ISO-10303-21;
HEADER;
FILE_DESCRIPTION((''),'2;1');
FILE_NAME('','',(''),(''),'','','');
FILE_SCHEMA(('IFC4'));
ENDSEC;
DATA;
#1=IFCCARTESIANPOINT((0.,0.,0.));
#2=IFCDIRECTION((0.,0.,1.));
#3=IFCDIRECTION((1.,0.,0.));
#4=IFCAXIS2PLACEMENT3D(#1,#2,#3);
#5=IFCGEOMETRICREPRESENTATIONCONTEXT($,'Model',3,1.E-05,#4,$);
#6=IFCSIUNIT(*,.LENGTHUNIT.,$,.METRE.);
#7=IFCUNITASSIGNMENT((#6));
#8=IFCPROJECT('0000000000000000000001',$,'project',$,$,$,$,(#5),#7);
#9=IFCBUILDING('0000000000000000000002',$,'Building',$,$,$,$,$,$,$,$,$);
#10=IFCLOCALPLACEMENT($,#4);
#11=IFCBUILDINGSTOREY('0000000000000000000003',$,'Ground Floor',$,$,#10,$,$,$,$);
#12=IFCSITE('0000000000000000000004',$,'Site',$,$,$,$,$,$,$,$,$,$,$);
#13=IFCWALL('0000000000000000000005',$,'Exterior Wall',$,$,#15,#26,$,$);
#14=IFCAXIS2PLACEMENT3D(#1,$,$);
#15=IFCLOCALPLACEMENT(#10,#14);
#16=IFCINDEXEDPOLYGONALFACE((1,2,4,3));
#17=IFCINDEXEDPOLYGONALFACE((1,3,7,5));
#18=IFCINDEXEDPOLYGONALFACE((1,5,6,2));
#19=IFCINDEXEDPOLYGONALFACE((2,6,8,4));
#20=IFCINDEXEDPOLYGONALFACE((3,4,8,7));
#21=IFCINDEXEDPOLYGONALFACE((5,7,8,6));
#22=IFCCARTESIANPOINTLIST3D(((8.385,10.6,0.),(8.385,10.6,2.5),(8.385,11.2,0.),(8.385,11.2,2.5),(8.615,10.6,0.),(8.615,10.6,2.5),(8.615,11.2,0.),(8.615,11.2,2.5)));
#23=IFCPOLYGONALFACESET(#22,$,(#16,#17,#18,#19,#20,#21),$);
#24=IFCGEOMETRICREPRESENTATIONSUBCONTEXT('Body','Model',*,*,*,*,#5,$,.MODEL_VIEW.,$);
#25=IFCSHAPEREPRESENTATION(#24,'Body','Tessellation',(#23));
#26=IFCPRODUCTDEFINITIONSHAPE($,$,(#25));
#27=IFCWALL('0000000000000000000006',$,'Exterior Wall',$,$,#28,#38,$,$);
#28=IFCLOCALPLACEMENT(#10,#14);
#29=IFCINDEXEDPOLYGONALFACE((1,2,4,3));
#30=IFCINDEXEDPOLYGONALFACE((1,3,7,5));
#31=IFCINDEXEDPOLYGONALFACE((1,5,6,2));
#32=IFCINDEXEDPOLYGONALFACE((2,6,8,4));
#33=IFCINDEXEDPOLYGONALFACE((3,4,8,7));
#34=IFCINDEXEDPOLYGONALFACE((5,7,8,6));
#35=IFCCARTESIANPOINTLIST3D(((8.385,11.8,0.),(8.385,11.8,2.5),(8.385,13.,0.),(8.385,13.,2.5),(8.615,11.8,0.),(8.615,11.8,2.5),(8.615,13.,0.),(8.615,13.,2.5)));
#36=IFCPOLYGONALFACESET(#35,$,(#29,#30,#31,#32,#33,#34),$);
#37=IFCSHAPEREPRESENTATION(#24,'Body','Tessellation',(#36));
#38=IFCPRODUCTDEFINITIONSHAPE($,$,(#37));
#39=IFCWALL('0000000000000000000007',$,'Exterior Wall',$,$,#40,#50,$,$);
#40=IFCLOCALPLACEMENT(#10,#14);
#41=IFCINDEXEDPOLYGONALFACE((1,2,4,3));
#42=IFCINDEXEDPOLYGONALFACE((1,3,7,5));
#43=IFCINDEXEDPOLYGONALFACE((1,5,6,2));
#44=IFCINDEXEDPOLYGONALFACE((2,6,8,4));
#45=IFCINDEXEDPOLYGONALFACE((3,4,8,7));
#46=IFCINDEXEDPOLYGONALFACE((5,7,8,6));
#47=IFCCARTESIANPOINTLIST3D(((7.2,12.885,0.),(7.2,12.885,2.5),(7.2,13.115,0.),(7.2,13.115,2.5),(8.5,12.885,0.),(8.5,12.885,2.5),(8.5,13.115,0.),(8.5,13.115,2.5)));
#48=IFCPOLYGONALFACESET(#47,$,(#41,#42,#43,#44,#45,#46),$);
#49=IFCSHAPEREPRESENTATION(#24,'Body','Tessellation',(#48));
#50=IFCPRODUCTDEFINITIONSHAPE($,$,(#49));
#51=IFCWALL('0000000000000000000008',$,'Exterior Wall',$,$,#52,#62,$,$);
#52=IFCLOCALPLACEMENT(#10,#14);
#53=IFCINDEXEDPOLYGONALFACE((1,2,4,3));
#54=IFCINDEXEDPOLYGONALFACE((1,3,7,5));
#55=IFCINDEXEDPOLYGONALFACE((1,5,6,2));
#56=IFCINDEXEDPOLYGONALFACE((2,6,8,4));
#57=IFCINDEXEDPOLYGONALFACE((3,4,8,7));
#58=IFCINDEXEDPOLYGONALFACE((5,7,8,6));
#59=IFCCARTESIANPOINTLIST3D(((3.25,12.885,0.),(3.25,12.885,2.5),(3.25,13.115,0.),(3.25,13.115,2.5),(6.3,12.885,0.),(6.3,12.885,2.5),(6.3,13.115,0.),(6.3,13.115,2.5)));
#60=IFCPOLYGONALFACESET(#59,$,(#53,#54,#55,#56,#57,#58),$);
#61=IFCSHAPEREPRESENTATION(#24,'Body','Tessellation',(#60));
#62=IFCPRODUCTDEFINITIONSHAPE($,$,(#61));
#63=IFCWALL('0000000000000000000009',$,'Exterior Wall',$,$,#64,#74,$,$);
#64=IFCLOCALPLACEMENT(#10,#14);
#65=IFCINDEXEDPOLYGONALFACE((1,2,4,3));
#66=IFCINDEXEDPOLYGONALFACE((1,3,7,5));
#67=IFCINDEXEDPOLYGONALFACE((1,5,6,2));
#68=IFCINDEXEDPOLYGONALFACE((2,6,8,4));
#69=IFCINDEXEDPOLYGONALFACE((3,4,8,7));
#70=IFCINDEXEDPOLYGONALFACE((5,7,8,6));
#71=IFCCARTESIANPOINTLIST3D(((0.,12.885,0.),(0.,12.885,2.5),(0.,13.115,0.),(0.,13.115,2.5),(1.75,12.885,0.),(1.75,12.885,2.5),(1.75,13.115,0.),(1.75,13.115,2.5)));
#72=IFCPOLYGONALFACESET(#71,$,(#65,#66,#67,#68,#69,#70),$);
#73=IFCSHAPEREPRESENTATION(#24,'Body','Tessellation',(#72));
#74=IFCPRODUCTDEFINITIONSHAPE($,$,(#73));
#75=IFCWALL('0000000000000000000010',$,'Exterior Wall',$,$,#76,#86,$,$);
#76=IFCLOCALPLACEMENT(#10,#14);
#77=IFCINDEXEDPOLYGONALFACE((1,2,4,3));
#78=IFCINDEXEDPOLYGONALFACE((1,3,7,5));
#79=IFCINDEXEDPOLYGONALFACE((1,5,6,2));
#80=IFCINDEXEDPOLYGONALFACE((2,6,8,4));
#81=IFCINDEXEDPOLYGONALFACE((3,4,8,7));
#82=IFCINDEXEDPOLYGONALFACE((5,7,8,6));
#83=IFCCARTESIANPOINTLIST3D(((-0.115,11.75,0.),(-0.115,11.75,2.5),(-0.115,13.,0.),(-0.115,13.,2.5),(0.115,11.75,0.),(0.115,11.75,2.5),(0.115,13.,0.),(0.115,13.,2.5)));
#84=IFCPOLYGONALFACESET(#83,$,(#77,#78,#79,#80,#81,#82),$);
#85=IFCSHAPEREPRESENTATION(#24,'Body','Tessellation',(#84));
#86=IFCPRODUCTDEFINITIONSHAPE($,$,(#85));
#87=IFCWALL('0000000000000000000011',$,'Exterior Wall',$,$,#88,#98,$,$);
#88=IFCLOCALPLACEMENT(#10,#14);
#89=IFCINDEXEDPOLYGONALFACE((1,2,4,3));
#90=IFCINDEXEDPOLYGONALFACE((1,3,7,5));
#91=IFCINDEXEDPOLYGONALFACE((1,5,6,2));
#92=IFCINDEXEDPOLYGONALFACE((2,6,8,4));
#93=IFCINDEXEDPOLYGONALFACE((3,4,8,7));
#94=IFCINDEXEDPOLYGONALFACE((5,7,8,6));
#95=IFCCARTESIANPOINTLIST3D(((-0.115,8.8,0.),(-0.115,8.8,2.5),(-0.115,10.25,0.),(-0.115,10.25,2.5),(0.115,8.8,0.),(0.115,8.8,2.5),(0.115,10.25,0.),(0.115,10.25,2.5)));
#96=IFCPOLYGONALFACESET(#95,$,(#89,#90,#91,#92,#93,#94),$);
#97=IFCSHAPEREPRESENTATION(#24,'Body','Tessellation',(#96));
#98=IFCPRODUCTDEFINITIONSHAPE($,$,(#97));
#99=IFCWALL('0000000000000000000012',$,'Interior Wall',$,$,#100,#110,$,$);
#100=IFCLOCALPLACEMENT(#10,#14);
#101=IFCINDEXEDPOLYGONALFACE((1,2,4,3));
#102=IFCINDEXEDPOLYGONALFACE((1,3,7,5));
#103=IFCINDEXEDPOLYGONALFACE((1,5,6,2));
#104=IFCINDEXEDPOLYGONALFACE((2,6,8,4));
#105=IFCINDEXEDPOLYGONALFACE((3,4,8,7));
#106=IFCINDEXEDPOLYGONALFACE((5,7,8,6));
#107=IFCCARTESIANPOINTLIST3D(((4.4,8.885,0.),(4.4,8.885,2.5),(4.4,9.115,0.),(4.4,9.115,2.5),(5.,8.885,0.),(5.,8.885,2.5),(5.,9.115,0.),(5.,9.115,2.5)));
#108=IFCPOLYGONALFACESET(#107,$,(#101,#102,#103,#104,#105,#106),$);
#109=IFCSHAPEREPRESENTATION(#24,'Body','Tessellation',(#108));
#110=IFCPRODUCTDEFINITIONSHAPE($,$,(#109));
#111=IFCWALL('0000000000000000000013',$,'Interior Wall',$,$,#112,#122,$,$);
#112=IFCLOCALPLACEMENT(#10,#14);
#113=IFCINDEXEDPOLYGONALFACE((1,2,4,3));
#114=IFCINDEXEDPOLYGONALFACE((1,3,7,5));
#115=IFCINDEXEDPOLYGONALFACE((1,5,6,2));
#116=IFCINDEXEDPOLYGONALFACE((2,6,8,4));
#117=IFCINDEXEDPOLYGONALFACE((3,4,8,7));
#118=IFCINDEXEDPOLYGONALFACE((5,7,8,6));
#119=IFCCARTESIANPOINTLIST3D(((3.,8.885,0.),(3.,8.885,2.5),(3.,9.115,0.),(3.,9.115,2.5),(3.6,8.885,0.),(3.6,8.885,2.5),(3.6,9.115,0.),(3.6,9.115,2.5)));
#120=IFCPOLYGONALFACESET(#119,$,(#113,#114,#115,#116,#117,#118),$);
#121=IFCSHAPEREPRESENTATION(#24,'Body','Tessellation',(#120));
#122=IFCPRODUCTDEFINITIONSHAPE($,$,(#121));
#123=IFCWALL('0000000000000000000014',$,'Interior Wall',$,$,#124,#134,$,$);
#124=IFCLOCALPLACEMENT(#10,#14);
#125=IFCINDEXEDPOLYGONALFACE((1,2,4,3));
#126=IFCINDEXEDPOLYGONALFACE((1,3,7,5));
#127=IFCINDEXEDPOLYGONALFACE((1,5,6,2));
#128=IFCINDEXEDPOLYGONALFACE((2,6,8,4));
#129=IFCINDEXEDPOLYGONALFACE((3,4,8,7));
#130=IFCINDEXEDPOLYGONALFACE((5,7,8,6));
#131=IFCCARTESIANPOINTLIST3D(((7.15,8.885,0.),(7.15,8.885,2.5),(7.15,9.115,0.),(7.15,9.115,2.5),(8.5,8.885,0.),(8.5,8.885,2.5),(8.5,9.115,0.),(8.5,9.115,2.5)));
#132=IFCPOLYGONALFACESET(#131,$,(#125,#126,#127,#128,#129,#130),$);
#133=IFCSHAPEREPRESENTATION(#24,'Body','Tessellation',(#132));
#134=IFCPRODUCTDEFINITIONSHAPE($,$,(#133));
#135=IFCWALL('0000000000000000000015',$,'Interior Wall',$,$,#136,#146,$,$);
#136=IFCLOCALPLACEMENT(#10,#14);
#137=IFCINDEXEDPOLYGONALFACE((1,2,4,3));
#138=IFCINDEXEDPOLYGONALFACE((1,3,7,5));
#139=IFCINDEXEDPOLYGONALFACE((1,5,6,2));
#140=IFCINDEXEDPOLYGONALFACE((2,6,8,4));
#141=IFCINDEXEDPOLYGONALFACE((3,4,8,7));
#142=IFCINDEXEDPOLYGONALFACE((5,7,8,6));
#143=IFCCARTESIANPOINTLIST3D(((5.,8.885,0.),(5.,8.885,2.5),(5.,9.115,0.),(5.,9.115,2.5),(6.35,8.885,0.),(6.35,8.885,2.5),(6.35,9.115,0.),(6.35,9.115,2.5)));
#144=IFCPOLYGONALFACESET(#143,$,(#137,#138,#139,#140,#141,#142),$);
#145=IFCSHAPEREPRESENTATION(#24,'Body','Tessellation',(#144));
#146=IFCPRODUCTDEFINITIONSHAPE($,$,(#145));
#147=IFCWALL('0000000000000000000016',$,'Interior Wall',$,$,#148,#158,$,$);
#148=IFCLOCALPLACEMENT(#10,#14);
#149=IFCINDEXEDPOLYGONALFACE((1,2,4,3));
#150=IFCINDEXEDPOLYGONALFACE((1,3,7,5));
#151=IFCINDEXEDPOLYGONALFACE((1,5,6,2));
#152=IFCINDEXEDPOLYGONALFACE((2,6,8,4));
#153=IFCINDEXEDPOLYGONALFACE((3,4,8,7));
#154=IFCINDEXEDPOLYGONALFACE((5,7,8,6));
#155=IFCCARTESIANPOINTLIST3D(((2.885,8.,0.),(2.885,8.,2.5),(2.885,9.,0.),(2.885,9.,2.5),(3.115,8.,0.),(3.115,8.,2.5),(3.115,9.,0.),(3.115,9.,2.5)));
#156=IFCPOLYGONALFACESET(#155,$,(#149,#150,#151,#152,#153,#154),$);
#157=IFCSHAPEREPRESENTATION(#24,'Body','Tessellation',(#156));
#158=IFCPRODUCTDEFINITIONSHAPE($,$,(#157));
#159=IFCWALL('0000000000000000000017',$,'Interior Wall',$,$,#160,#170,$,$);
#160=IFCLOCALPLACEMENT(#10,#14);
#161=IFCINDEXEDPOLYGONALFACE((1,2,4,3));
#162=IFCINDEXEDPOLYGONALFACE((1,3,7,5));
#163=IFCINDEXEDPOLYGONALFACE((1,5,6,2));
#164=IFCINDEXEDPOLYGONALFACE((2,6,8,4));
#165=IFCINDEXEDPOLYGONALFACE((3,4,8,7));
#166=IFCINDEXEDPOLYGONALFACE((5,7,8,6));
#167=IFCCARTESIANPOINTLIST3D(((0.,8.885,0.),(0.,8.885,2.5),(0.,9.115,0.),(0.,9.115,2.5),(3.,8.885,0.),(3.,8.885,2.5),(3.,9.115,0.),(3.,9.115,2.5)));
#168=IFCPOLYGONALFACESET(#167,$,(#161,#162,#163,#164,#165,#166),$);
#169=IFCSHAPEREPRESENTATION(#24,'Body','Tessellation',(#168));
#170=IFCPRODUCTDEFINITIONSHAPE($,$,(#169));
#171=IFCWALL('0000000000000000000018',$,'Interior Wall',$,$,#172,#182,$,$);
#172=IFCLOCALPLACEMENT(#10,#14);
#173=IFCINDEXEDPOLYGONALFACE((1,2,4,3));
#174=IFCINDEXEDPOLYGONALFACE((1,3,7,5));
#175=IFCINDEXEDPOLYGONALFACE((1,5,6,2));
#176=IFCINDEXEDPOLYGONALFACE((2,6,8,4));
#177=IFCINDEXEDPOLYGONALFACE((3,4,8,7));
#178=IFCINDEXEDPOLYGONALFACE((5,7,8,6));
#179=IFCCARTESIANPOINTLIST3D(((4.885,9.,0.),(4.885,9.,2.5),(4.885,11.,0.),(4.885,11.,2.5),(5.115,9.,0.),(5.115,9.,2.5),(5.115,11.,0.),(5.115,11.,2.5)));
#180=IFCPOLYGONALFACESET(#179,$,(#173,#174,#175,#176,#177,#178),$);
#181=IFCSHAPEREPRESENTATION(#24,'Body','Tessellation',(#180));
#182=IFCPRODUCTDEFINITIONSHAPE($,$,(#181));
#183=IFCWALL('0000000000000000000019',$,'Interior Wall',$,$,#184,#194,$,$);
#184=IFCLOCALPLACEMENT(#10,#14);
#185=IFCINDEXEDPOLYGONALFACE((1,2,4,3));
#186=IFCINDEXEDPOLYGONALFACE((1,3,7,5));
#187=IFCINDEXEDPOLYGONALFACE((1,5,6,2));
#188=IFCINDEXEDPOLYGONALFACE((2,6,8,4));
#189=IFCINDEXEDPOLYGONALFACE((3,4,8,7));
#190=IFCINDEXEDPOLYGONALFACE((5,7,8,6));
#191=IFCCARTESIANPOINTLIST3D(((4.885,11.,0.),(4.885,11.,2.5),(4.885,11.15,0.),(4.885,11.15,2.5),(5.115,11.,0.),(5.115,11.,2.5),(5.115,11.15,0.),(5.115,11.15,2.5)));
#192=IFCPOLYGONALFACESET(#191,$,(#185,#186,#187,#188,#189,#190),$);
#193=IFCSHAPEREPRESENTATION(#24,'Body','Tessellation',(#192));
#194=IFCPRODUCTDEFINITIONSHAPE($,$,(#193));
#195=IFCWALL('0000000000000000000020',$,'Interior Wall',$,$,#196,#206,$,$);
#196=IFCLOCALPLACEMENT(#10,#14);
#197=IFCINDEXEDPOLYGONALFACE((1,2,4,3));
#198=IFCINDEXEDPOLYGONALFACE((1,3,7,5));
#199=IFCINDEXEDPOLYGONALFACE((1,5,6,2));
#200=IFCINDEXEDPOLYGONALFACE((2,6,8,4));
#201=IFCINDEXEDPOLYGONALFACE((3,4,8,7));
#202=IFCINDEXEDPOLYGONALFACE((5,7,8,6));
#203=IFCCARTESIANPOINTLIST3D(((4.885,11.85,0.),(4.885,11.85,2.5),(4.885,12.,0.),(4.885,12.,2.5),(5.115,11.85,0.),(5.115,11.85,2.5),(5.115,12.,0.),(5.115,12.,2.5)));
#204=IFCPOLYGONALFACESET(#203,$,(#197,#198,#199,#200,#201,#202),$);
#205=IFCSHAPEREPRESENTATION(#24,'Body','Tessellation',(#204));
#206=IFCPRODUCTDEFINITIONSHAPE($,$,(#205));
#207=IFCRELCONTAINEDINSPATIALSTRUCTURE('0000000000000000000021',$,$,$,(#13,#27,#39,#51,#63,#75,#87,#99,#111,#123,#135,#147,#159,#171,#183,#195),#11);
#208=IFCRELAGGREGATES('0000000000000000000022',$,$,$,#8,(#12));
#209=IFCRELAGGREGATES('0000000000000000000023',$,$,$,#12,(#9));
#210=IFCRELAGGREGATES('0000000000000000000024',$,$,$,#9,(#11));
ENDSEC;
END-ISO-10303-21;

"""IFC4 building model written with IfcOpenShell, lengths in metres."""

from ifc_helpers import new_model, si_unit, frame, origin_with_axes, place, context, subcontext, project, spatial, indexed_curve, outline, extrude, element, save


model = new_model("IFC4")

# Units and contexts
model_context = context("Model", 3, precision=1e-05, world=origin_with_axes())
body_context = subcontext(model_context, "Body", "Model", "MODEL_VIEW")
ifc_project = project(units=[si_unit("LENGTHUNIT", "METRE")], contexts=[model_context])

# Site, building, storey
site = spatial("IfcSite", under=ifc_project, Name="Site")
building = spatial("IfcBuilding", under=site, Name="Building")
storey_placement = place(None, origin_with_axes())
storey = spatial("IfcBuildingStorey", under=building, at=storey_placement, Name="Ground Floor")

# Walls
wall_1_placement = place(storey_placement, frame((8.5, 10.6, 0.0), z_axis=(0.0, 0.0, 1.0), x_axis=(0.0, 1.0, 0.0)))
element("IfcWall", 1, at=wall_1_placement, inside=storey, Name="Exterior Wall", context=body_context, shape_type="SweptSolid", body=[
    extrude(outline(indexed_curve([(0.0, 0.0), (0.0, 0.23), (0.6, 0.23), (0.6, 0.0), (0.0, 0.0)], self_intersect=False)), frame((0.0, -0.115, 0.0), z_axis=(0.0, 0.0, 1.0), x_axis=(1.0, 0.0, 0.0)), (0.0, 0.0, 1.0), 2.5),
])
wall_2_placement = place(storey_placement, frame((8.5, 11.8, 0.0), z_axis=(0.0, 0.0, 1.0), x_axis=(0.0, 1.0, 0.0)))
element("IfcWall", 2, at=wall_2_placement, inside=storey, Name="Exterior Wall", context=body_context, shape_type="SweptSolid", body=[
    extrude(outline(indexed_curve([(0.0, 0.0), (0.0, 0.23), (1.2, 0.23), (1.2, 0.0), (0.0, 0.0)], self_intersect=False)), frame((0.0, -0.115, 0.0), z_axis=(0.0, 0.0, 1.0), x_axis=(1.0, 0.0, 0.0)), (0.0, 0.0, 1.0), 2.5),
])
wall_3_placement = place(storey_placement, frame((8.5, 13.0, 0.0), z_axis=(0.0, 0.0, 1.0), x_axis=(-1.0, 0.0, 0.0)))
element("IfcWall", 3, at=wall_3_placement, inside=storey, Name="Exterior Wall", context=body_context, shape_type="SweptSolid", body=[
    extrude(outline(indexed_curve([(0.0, 0.0), (0.0, 0.23), (1.3, 0.23), (1.3, 0.0), (0.0, 0.0)], self_intersect=False)), frame((0.0, -0.115, 0.0), z_axis=(0.0, 0.0, 1.0), x_axis=(1.0, 0.0, 0.0)), (0.0, 0.0, 1.0), 2.5),
])
wall_4_placement = place(storey_placement, frame((6.3, 13.0, 0.0), z_axis=(0.0, 0.0, 1.0), x_axis=(-1.0, 0.0, 0.0)))
element("IfcWall", 4, at=wall_4_placement, inside=storey, Name="Exterior Wall", context=body_context, shape_type="SweptSolid", body=[
    extrude(outline(indexed_curve([(0.0, 0.0), (0.0, 0.23), (3.05, 0.23), (3.05, 0.0), (0.0, 0.0)], self_intersect=False)), frame((0.0, -0.115, 0.0), z_axis=(0.0, 0.0, 1.0), x_axis=(1.0, 0.0, 0.0)), (0.0, 0.0, 1.0), 2.5),
])
wall_5_placement = place(storey_placement, frame((1.75, 13.0, 0.0), z_axis=(0.0, 0.0, 1.0), x_axis=(-1.0, 0.0, 0.0)))
element("IfcWall", 5, at=wall_5_placement, inside=storey, Name="Exterior Wall", context=body_context, shape_type="SweptSolid", body=[
    extrude(outline(indexed_curve([(0.0, 0.0), (0.0, 0.23), (1.75, 0.23), (1.75, 0.0), (0.0, 0.0)], self_intersect=False)), frame((0.0, -0.115, 0.0), z_axis=(0.0, 0.0, 1.0), x_axis=(1.0, 0.0, 0.0)), (0.0, 0.0, 1.0), 2.5),
])
wall_6_placement = place(storey_placement, frame((0.0, 13.0, 0.0), z_axis=(0.0, 0.0, 1.0), x_axis=(0.0, -1.0, 0.0)))
element("IfcWall", 6, at=wall_6_placement, inside=storey, Name="Exterior Wall", context=body_context, shape_type="SweptSolid", body=[
    extrude(outline(indexed_curve([(0.0, 0.0), (0.0, 0.23), (1.25, 0.23), (1.25, 0.0), (0.0, 0.0)], self_intersect=False)), frame((0.0, -0.115, 0.0), z_axis=(0.0, 0.0, 1.0), x_axis=(1.0, 0.0, 0.0)), (0.0, 0.0, 1.0), 2.5),
])
wall_7_placement = place(storey_placement, frame((0.0, 10.25, 0.0), z_axis=(0.0, 0.0, 1.0), x_axis=(0.0, -1.0, 0.0)))
element("IfcWall", 7, at=wall_7_placement, inside=storey, Name="Exterior Wall", context=body_context, shape_type="SweptSolid", body=[
    extrude(outline(indexed_curve([(0.0, 0.0), (0.0, 0.23), (1.45, 0.23), (1.45, 0.0), (0.0, 0.0)], self_intersect=False)), frame((0.0, -0.115, 0.0), z_axis=(0.0, 0.0, 1.0), x_axis=(1.0, 0.0, 0.0)), (0.0, 0.0, 1.0), 2.5),
])
wall_8_placement = place(storey_placement, frame((5.0, 9.0, 0.0), z_axis=(0.0, 0.0, 1.0), x_axis=(-1.0, 0.0, 0.0)))
element("IfcWall", 8, at=wall_8_placement, inside=storey, Name="Interior Wall", context=body_context, shape_type="SweptSolid", body=[
    extrude(outline(indexed_curve([(0.0, 0.0), (0.0, 0.23), (0.6, 0.23), (0.6, 0.0), (0.0, 0.0)], self_intersect=False)), frame((0.0, -0.115, 0.0), z_axis=(0.0, 0.0, 1.0), x_axis=(1.0, 0.0, 0.0)), (0.0, 0.0, 1.0), 2.5),
])
wall_9_placement = place(storey_placement, frame((3.6, 9.0, 0.0), z_axis=(0.0, 0.0, 1.0), x_axis=(-1.0, 0.0, 0.0)))
element("IfcWall", 9, at=wall_9_placement, inside=storey, Name="Interior Wall", context=body_context, shape_type="SweptSolid", body=[
    extrude(outline(indexed_curve([(0.0, 0.0), (0.0, 0.23), (0.6, 0.23), (0.6, 0.0), (0.0, 0.0)], self_intersect=False)), frame((0.0, -0.115, 0.0), z_axis=(0.0, 0.0, 1.0), x_axis=(1.0, 0.0, 0.0)), (0.0, 0.0, 1.0), 2.5),
])
for number, where, z_axis, x_axis, name in (
    (10, (8.5, 9.0, 0.0), (0.0, 0.0, 1.0), (-1.0, 0.0, 0.0), "Interior Wall"),
    (11, (6.35, 9.0, 0.0), (0.0, 0.0, 1.0), (-1.0, 0.0, 0.0), "Interior Wall"),
):
    element("IfcWall", number, at=place(storey_placement, frame(where, z_axis=z_axis, x_axis=x_axis)), inside=storey, Name=name, context=body_context, shape_type="SweptSolid", body=[
        extrude(outline(indexed_curve([(0.0, 0.0), (0.0, 0.23), (1.35, 0.23), (1.35, 0.0), (0.0, 0.0)], self_intersect=False)), frame((0.0, -0.115, 0.0), z_axis=(0.0, 0.0, 1.0), x_axis=(1.0, 0.0, 0.0)), (0.0, 0.0, 1.0), 2.5),
    ])
wall_10_placement = place(storey_placement, frame((3.0, 9.0, 0.0), z_axis=(0.0, 0.0, 1.0), x_axis=(0.0, -1.0, 0.0)))
element("IfcWall", 12, at=wall_10_placement, inside=storey, Name="Interior Wall", context=body_context, shape_type="SweptSolid", body=[
    extrude(outline(indexed_curve([(0.0, 0.0), (0.0, 0.23), (1.0, 0.23), (1.0, 0.0), (0.0, 0.0)], self_intersect=False)), frame((0.0, -0.115, 0.0), z_axis=(0.0, 0.0, 1.0), x_axis=(1.0, 0.0, 0.0)), (0.0, 0.0, 1.0), 2.5),
])
wall_11_placement = place(storey_placement, frame((3.0, 9.0, 0.0), z_axis=(0.0, 0.0, 1.0), x_axis=(-1.0, 0.0, 0.0)))
element("IfcWall", 13, at=wall_11_placement, inside=storey, Name="Interior Wall", context=body_context, shape_type="SweptSolid", body=[
    extrude(outline(indexed_curve([(0.0, 0.0), (0.0, 0.23), (3.0, 0.23), (3.0, 0.0), (0.0, 0.0)], self_intersect=False)), frame((0.0, -0.115, 0.0), z_axis=(0.0, 0.0, 1.0), x_axis=(1.0, 0.0, 0.0)), (0.0, 0.0, 1.0), 2.5),
])
wall_12_placement = place(storey_placement, frame((5.0, 9.0, 0.0), z_axis=(0.0, 0.0, 1.0), x_axis=(0.0, 1.0, 0.0)))
element("IfcWall", 14, at=wall_12_placement, inside=storey, Name="Interior Wall", context=body_context, shape_type="SweptSolid", body=[
    extrude(outline(indexed_curve([(0.0, 0.0), (0.0, 0.23), (2.0, 0.23), (2.0, 0.0), (0.0, 0.0)], self_intersect=False)), frame((0.0, -0.115, 0.0), z_axis=(0.0, 0.0, 1.0), x_axis=(1.0, 0.0, 0.0)), (0.0, 0.0, 1.0), 2.5),
])
for number, where, z_axis, x_axis, name in (
    (15, (5.0, 11.0, 0.0), (0.0, 0.0, 1.0), (0.0, 1.0, 0.0), "Interior Wall"),
    (16, (5.0, 11.85, 0.0), (0.0, 0.0, 1.0), (0.0, 1.0, 0.0), "Interior Wall"),
):
    element("IfcWall", number, at=place(storey_placement, frame(where, z_axis=z_axis, x_axis=x_axis)), inside=storey, Name=name, context=body_context, shape_type="SweptSolid", body=[
        extrude(outline(indexed_curve([(0.0, 0.0), (0.0, 0.23), (0.15, 0.23), (0.15, 0.0), (0.0, 0.0)], self_intersect=False)), frame((0.0, -0.115, 0.0), z_axis=(0.0, 0.0, 1.0), x_axis=(1.0, 0.0, 0.0)), (0.0, 0.0, 1.0), 2.5),
    ])

save(model, "model.ifc")
